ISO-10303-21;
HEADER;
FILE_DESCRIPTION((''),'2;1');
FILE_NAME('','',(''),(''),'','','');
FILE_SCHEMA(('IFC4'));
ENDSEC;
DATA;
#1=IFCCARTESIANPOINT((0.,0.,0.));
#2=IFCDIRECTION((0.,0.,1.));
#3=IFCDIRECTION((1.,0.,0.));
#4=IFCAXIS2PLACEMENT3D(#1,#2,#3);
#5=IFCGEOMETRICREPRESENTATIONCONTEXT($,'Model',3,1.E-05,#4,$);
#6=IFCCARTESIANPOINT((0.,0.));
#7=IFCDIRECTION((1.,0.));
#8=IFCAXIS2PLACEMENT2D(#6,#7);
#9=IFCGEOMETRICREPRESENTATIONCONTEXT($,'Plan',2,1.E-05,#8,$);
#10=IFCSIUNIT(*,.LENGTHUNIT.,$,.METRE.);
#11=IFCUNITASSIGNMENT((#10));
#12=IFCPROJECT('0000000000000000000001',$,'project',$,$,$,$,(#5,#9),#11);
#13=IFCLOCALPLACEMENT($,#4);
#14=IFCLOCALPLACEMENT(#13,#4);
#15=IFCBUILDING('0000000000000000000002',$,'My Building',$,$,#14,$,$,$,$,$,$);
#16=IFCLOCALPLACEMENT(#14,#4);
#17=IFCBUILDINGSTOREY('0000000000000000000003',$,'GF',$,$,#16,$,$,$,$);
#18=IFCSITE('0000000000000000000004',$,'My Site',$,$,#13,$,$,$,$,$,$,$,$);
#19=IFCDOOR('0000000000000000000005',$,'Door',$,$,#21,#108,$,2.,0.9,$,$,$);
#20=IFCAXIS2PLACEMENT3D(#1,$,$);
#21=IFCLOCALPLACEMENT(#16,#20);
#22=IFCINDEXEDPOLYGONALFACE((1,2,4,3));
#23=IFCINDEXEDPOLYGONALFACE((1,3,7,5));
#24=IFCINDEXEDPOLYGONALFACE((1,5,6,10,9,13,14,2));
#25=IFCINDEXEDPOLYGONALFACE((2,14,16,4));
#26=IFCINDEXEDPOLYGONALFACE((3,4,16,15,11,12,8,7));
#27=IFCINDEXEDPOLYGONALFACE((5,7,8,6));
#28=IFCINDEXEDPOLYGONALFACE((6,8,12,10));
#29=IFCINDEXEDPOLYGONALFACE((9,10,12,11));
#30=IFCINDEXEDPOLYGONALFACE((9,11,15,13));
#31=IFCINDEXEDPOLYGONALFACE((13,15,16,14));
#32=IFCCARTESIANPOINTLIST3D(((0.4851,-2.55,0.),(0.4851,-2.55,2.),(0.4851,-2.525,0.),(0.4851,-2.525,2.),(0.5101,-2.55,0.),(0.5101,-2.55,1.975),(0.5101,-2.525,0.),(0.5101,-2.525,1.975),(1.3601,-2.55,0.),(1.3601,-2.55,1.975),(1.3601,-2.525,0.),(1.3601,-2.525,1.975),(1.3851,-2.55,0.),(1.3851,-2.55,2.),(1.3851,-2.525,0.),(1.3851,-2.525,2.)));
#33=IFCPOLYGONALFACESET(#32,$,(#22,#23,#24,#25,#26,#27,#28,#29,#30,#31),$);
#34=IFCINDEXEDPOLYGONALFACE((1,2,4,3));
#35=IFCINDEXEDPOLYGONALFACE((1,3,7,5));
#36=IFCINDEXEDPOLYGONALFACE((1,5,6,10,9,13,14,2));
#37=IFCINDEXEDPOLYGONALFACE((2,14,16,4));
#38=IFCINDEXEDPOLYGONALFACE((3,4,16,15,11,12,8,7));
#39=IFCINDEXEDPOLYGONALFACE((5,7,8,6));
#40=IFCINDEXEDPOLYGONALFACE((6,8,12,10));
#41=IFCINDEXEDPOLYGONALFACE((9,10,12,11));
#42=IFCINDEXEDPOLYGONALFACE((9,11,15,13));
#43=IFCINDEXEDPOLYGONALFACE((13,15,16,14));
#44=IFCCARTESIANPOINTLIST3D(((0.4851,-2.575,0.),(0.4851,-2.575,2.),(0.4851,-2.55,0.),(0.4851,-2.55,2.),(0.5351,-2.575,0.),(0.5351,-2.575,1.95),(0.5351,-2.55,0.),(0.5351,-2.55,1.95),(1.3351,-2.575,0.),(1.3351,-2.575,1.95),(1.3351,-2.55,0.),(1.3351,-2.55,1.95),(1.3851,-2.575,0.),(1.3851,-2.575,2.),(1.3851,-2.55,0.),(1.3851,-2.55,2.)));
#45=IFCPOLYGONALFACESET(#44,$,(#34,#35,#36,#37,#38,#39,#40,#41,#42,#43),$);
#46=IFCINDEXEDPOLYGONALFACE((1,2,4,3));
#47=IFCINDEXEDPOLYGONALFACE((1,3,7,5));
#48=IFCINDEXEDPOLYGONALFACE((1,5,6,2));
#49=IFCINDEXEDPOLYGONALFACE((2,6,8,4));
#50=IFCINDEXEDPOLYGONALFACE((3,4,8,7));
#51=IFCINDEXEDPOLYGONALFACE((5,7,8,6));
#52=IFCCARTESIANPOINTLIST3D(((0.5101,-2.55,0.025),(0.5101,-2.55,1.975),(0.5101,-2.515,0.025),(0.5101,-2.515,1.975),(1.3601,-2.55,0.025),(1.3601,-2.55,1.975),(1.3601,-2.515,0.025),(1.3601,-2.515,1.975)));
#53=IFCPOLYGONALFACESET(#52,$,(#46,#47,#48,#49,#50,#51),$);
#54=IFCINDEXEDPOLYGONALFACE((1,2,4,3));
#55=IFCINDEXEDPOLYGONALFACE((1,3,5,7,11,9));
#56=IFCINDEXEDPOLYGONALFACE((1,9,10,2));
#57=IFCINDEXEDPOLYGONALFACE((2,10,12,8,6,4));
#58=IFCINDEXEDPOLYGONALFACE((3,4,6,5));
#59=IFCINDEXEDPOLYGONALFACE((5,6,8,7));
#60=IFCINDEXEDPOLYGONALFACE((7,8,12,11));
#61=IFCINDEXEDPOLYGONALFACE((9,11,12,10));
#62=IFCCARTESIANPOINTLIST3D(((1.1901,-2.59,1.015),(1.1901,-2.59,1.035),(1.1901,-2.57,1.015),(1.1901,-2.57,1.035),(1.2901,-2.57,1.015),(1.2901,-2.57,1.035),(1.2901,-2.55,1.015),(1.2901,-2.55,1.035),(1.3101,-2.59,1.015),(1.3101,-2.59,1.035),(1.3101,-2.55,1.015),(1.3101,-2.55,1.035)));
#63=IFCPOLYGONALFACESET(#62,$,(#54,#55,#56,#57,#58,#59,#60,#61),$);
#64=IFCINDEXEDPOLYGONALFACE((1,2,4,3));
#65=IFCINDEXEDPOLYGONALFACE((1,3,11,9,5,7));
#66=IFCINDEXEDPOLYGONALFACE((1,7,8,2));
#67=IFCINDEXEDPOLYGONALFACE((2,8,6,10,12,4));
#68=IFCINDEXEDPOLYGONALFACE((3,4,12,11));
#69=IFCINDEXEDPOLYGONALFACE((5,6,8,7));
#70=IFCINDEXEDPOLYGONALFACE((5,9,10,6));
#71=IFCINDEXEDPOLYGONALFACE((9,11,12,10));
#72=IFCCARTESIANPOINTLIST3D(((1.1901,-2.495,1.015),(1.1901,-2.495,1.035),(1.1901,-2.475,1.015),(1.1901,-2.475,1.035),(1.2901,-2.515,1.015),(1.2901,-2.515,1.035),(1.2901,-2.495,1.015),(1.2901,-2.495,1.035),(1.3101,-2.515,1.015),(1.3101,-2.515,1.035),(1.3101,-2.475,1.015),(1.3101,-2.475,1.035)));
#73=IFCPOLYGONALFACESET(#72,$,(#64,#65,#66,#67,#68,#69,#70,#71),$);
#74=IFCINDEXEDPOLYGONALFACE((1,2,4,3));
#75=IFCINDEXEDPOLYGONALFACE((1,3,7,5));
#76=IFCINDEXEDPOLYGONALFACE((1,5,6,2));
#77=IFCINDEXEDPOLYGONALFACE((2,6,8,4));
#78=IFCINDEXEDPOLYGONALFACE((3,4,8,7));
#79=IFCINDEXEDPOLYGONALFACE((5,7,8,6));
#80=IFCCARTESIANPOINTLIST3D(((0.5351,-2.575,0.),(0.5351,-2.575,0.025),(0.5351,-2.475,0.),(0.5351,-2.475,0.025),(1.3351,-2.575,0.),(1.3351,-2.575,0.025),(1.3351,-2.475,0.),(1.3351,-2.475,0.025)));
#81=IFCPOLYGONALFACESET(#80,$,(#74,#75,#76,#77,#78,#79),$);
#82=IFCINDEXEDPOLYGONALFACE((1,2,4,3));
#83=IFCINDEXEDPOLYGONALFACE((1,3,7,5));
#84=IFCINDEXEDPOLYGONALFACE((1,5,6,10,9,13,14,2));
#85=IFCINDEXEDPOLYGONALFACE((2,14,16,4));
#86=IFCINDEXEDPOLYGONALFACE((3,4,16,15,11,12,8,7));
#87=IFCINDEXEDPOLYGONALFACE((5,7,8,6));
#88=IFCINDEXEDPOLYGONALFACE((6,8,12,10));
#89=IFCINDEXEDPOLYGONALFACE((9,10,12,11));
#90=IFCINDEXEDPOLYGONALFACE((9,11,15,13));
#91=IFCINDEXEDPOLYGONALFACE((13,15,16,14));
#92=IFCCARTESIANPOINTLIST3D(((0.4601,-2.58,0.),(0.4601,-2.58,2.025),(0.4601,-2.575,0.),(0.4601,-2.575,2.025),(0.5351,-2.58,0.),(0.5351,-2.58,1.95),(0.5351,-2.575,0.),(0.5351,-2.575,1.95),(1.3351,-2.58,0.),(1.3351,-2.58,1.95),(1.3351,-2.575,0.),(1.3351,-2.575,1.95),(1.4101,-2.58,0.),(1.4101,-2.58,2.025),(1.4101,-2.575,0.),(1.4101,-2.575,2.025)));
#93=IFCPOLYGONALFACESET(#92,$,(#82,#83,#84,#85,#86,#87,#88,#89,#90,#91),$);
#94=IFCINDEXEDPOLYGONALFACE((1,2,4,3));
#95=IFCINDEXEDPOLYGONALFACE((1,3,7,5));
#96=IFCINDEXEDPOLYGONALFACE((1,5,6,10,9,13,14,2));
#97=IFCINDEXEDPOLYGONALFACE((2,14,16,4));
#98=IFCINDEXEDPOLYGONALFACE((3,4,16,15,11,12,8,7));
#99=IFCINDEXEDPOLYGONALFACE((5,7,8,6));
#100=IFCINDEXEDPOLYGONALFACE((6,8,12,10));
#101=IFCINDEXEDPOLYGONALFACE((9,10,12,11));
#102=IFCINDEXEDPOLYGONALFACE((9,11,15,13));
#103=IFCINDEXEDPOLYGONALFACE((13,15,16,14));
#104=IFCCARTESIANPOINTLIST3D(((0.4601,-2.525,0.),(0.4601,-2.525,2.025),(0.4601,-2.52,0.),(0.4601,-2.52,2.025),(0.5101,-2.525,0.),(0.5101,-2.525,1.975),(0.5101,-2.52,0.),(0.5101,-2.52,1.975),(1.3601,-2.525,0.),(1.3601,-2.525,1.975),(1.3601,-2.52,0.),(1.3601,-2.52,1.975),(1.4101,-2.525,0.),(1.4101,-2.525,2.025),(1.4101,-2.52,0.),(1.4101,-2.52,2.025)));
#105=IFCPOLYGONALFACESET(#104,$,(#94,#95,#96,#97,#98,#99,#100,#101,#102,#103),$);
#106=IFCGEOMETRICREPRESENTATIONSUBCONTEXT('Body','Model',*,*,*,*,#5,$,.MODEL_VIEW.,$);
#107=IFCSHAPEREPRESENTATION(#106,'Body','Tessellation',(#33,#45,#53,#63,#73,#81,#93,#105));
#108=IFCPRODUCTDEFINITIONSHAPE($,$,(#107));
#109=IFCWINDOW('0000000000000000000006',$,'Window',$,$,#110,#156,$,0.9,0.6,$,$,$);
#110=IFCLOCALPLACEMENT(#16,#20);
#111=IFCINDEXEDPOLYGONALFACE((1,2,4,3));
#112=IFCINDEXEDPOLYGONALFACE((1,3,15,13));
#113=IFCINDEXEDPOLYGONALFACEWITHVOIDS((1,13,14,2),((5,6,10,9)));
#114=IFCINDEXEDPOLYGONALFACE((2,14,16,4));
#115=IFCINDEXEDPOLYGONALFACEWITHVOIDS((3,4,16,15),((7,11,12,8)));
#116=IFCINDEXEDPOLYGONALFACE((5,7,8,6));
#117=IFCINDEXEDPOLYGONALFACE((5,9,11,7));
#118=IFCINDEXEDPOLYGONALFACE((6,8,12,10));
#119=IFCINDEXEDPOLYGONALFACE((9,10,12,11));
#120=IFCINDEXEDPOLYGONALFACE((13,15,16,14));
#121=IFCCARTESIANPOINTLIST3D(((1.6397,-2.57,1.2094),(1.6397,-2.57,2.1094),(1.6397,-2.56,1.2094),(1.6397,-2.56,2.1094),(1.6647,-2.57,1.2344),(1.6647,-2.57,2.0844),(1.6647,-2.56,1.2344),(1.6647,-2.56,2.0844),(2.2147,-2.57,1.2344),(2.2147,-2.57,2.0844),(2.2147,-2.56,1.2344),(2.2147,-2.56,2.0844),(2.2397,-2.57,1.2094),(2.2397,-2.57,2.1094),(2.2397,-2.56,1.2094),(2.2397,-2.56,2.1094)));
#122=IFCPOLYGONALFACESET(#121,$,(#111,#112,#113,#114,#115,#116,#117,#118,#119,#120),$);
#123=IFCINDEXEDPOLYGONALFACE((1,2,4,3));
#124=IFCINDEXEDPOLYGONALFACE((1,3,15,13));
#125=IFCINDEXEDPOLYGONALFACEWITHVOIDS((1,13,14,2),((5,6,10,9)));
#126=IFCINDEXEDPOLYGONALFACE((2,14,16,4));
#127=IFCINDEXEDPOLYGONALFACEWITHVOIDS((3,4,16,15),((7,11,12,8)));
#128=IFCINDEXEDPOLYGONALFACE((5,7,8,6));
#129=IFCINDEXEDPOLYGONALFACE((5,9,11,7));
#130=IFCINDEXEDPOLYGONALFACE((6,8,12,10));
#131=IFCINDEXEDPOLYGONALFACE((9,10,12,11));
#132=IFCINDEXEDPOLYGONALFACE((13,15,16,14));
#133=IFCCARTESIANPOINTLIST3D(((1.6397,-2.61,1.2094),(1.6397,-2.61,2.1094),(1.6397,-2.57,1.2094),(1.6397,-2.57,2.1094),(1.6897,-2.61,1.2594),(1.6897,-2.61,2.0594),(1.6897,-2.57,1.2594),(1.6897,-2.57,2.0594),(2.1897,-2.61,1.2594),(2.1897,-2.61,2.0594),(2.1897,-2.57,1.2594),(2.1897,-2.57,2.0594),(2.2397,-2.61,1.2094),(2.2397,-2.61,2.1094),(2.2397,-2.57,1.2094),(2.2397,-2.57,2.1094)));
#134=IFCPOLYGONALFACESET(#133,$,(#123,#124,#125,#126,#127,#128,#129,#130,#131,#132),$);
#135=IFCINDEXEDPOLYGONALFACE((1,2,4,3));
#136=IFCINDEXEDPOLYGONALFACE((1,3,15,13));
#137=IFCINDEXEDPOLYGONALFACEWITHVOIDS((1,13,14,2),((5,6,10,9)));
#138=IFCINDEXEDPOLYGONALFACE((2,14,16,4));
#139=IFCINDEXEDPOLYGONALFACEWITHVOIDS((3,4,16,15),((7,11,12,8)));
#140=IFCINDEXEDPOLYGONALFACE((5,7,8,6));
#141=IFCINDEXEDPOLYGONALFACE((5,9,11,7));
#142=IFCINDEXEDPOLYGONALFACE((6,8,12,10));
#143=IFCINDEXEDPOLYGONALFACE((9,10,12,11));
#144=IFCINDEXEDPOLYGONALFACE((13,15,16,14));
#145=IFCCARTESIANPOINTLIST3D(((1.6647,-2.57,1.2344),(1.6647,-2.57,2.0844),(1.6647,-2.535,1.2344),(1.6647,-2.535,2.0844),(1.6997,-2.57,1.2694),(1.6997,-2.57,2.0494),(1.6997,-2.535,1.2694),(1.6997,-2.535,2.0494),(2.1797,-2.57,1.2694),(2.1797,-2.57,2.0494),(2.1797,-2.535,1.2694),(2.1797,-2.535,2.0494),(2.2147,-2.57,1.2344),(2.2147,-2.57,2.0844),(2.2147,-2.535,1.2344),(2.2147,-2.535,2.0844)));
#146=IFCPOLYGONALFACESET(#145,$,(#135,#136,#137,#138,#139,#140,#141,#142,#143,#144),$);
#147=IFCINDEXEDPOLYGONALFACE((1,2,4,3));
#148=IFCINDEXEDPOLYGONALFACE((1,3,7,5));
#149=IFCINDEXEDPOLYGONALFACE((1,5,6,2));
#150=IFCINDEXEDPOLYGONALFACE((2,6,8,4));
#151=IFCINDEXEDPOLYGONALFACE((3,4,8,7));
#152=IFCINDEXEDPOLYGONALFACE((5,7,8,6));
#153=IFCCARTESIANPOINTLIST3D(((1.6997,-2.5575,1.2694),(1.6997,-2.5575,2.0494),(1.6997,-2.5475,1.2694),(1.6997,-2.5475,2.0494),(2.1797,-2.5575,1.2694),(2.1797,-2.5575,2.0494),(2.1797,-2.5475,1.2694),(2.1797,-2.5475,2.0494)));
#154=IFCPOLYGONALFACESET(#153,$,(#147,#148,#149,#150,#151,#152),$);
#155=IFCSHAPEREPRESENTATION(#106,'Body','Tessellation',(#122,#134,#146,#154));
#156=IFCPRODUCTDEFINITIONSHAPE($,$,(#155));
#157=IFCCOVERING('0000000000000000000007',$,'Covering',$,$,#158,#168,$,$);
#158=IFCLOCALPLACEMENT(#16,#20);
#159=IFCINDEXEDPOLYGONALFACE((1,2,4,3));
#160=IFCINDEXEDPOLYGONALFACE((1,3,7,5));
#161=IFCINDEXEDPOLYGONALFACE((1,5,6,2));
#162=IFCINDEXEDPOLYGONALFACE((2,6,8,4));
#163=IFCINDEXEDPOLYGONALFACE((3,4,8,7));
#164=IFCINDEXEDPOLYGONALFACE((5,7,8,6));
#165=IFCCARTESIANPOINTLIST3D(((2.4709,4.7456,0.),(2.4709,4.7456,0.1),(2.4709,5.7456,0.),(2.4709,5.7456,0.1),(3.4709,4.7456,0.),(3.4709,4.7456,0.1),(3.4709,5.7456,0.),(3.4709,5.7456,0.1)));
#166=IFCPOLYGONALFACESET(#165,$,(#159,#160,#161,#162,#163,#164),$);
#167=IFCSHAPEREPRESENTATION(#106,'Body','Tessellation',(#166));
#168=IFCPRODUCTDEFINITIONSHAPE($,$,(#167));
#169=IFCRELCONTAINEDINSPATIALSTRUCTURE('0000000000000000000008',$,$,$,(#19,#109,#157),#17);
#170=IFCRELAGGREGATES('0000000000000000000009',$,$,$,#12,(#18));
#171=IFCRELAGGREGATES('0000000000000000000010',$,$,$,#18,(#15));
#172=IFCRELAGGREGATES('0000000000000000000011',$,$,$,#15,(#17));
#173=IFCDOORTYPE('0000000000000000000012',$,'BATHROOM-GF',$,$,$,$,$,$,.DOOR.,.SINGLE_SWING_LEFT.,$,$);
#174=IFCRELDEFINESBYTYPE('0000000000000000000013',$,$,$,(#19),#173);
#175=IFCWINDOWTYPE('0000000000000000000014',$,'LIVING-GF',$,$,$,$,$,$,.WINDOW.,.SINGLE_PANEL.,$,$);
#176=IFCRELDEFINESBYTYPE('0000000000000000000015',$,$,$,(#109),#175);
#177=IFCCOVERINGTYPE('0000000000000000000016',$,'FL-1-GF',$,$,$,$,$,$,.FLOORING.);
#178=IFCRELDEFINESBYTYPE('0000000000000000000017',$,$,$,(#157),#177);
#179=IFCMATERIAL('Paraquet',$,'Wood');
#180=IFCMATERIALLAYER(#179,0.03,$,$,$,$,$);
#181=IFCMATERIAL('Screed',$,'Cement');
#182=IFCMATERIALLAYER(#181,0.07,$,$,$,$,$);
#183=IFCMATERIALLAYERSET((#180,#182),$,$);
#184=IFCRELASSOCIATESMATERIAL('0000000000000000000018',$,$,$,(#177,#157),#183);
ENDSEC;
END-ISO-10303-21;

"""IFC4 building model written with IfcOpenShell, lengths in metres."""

from ifc_helpers import new_model, entity, si_unit, frame, origin_with_axes, origin_2d_with_axis, place, context, subcontext, project, spatial, line, indexed_curve, outline, extrude, shape, source, transform, mapped, material, layer, layer_set, layer_usage, type_object, type_shapes, element, save


model = new_model("IFC4")

# Units and contexts
model_context = context("Model", 3, precision=1e-05, world=origin_with_axes())
plan_context = context("Plan", 2, precision=1e-05, world=origin_2d_with_axis())
body_context_1 = subcontext(model_context, "Body", "Model", "MODEL_VIEW")
body_context_2 = subcontext(plan_context, "Body", "Plan", "PLAN_VIEW")
ifc_project = project(units=[si_unit("LENGTHUNIT", "METRE")], contexts=[model_context, plan_context])

# Site, building, storey
site_placement = place(None, origin_with_axes())
site = spatial("IfcSite", under=ifc_project, at=site_placement, Name="My Site")
building_placement = place(site_placement, origin_with_axes())
building = spatial("IfcBuilding", under=site, at=building_placement, Name="My Building")
storey_placement = place(building_placement, origin_with_axes())
storey = spatial("IfcBuildingStorey", under=building, at=storey_placement, Name="GF")

# Shared definitions
door_type_1 = type_object("IfcDoorType", Name="BATHROOM-GF", OperationType="SINGLE_SWING_LEFT", PredefinedType="DOOR")
shared_shape_1 = source(origin_with_axes(), body_context_1, "Body", "SweptSolid", [
    extrude(outline(indexed_curve([(0.0, 0.0), (0.0, 2.0), (0.9, 2.0), (0.9, 0.0), (0.875, 0.0), (0.875, 1.975), (0.025, 1.975), (0.025, 0.0)], segments=[line(1, 2, 3, 4, 5, 6, 7, 8, 1)])), frame((0.0, 0.025, 0.0), z_axis=(0.0, -1.0, 0.0), x_axis=(1.0, 0.0, 0.0)), (0.0, 0.0, -1.0), 0.025),
    extrude(outline(indexed_curve([(0.0, 0.0), (0.0, 2.0), (0.9, 2.0), (0.9, 0.0), (0.85, 0.0), (0.85, 1.95), (0.05, 1.95), (0.05, 0.0)], segments=[line(1, 2, 3, 4, 5, 6, 7, 8, 1)])), frame((0.0, 0.0, 0.0), z_axis=(0.0, -1.0, 0.0), x_axis=(1.0, 0.0, 0.0)), (0.0, 0.0, -1.0), 0.025),
    extrude(outline(indexed_curve([(0.0, 0.0), (0.85, 0.0), (0.85, 0.035), (0.0, 0.035)], segments=[line(1, 2, 3, 4, 1)])), frame((0.025, 0.025, 0.025), z_axis=(0.0, 0.0, 1.0), x_axis=(1.0, 0.0, 0.0)), (0.0, 0.0, 1.0), 1.95),
    extrude(outline(indexed_curve([(0.0, 0.0), (0.0, -0.04), (-0.12, -0.04), (-0.12, -0.02), (-0.02, -0.02), (-0.02, 0.0)], segments=[line(1, 2, 3, 4, 5, 6, 1)])), frame((0.825, 0.025, 1.015), z_axis=(0.0, 0.0, 1.0), x_axis=(1.0, 0.0, 0.0)), (0.0, 0.0, 1.0), 0.02),
    extrude(outline(indexed_curve([(0.0, 0.0), (0.0, 0.04), (-0.12, 0.04), (-0.12, 0.02), (-0.02, 0.02), (-0.02, 0.0)], segments=[line(1, 2, 3, 4, 5, 6, 1)])), frame((0.825, 0.06, 1.015), z_axis=(0.0, 0.0, 1.0), x_axis=(1.0, 0.0, 0.0)), (0.0, 0.0, 1.0), 0.02),
    extrude(outline(indexed_curve([(0.0, 0.0), (0.8, 0.0), (0.8, 0.1), (0.0, 0.1)], segments=[line(1, 2, 3, 4, 1)])), frame((0.05, 0.0, 0.0), z_axis=(0.0, 0.0, 1.0), x_axis=(1.0, 0.0, 0.0)), (0.0, 0.0, 1.0), 0.025),
    extrude(outline(indexed_curve([(0.0, 0.0), (0.0, 2.025), (0.95, 2.025), (0.95, 0.0), (0.875, 0.0), (0.875, 1.95), (0.075, 1.95), (0.075, 0.0)], segments=[line(1, 2, 3, 4, 5, 6, 7, 8, 1)])), frame((-0.025, -0.005, 0.0), z_axis=(0.0, -1.0, 0.0), x_axis=(1.0, 0.0, 0.0)), (0.0, 0.0, -1.0), 0.005),
    extrude(outline(indexed_curve([(0.0, 0.0), (0.0, 2.025), (0.95, 2.025), (0.95, 0.0), (0.9, 0.0), (0.9, 1.975), (0.05, 1.975), (0.05, 0.0)], segments=[line(1, 2, 3, 4, 5, 6, 7, 8, 1)])), frame((-0.025, 0.05, 0.0), z_axis=(0.0, -1.0, 0.0), x_axis=(1.0, 0.0, 0.0)), (0.0, 0.0, -1.0), 0.005),
])
shared_shape_2 = source(origin_with_axes(), body_context_2, "Body", "Curve2D", [
    entity("IfcIndexedPolyCurve", entity("IfcCartesianPointList2D", [[0.0, 0.0], [0.0, 0.05], [0.025, 0.05], [0.025, 0.025], [0.05, 0.025], [0.05, 0.0]]), [entity("IfcLineIndex", [1, 2, 3, 4, 5, 6, 1])]),
    entity("IfcIndexedPolyCurve", entity("IfcCartesianPointList2D", [[0.9, 0.0], [0.9, 0.05], [0.875, 0.05], [0.875, 0.025], [0.85, 0.025], [0.85, 0.0]]), [entity("IfcLineIndex", [1, 2, 3, 4, 5, 6, 1])]),
    entity("IfcTrimmedCurve", entity("IfcEllipse", entity("IfcAxis2Placement2D", entity("IfcCartesianPoint", [0.06, 0.05]), entity("IfcDirection", [1.0, 0.0])), 0.815, 0.85), [entity("IfcCartesianPoint", [0.875, 0.05])], [entity("IfcCartesianPoint", [0.06, 0.9])], True, "CARTESIAN"),
    entity("IfcIndexedPolyCurve", entity("IfcCartesianPointList2D", [[0.025, 0.05], [0.06, 0.05], [0.06, 0.9], [0.025, 0.9]]), [entity("IfcLineIndex", [1, 2, 3, 4, 1])]),
])
type_shapes(door_type_1, [shared_shape_1, shared_shape_2])

# Door
door_1_placement = place(storey_placement, frame((0.4851, -2.575, 0.0), z_axis=(0.0, 0.0, 1.0), x_axis=(1.0, 0.0, 0.0)))
element("IfcDoor", 1, at=door_1_placement, inside=storey, type_object=door_type_1, Name="Door", OverallHeight=2.0, OverallWidth=0.9, shapes=[
    shape(body_context_1, "Body", "MappedRepresentation", [mapped(shared_shape_1, transform((0.0, 0.0, 0.0), x_axis=(1.0, 0.0, 0.0), y_axis=(0.0, 1.0, 0.0), z_axis=(0.0, 0.0, 1.0), scale=1.0))]),
    shape(body_context_2, "Body", "MappedRepresentation", [mapped(shared_shape_2, transform((0.0, 0.0, 0.0), x_axis=(1.0, 0.0, 0.0), y_axis=(0.0, 1.0, 0.0), z_axis=(0.0, 0.0, 1.0), scale=1.0))]),
])

# Window
window_type_1 = type_object("IfcWindowType", Name="LIVING-GF", PartitioningType="SINGLE_PANEL", PredefinedType="WINDOW")
shared_shape_3 = source(origin_with_axes(), body_context_1, "Body", "SweptSolid", [
    extrude(outline(indexed_curve([(0.0, 0.0), (0.6, 0.0), (0.6, 0.9), (0.0, 0.9)], segments=[line(1, 2, 3, 4, 1)]), holes=[indexed_curve([(0.025, 0.025), (0.575, 0.025), (0.575, 0.875), (0.025, 0.875)], segments=[line(1, 2, 3, 4, 1)])]), frame((0.0, 0.09, 0.0), z_axis=(0.0, -1.0, 0.0), x_axis=(1.0, 0.0, 0.0)), (0.0, 0.0, -1.0), 0.01),
    extrude(outline(indexed_curve([(0.0, 0.0), (0.6, 0.0), (0.6, 0.9), (0.0, 0.9)], segments=[line(1, 2, 3, 4, 1)]), holes=[indexed_curve([(0.05, 0.05), (0.55, 0.05), (0.55, 0.85), (0.05, 0.85)], segments=[line(1, 2, 3, 4, 1)])]), frame((0.0, 0.05, 0.0), z_axis=(0.0, -1.0, 0.0), x_axis=(1.0, 0.0, 0.0)), (0.0, 0.0, -1.0), 0.04),
    extrude(outline(indexed_curve([(0.0, 0.0), (0.55, 0.0), (0.55, 0.85), (0.0, 0.85)], segments=[line(1, 2, 3, 4, 1)]), holes=[indexed_curve([(0.035, 0.035), (0.515, 0.035), (0.515, 0.815), (0.035, 0.815)], segments=[line(1, 2, 3, 4, 1)])]), frame((0.025, 0.09, 0.025), z_axis=(0.0, -1.0, 0.0), x_axis=(1.0, 0.0, 0.0)), (0.0, 0.0, -1.0), 0.035),
    extrude(outline(indexed_curve([(0.035, 0.035), (0.515, 0.035), (0.515, 0.815), (0.035, 0.815)], segments=[line(1, 2, 3, 4, 1)])), frame((0.025, 0.1025, 0.025), z_axis=(0.0, -1.0, 0.0), x_axis=(1.0, 0.0, 0.0)), (0.0, 0.0, -1.0), 0.01),
])
shared_shape_4 = source(origin_with_axes(), body_context_2, "Body", "Curve2D", [
    entity("IfcIndexedPolyCurve", entity("IfcCartesianPointList2D", [[0.05, 0.05], [0.55, 0.05]])),
    entity("IfcIndexedPolyCurve", entity("IfcCartesianPointList2D", [[0.0, 0.1], [0.025, 0.1], [0.025, 0.09], [0.05, 0.09], [0.05, 0.05], [0.0, 0.05]]), [entity("IfcLineIndex", [1, 2, 3, 4, 5, 6, 1])]),
    entity("IfcIndexedPolyCurve", entity("IfcCartesianPointList2D", [[0.6, 0.1], [0.575, 0.1], [0.575, 0.09], [0.55, 0.09], [0.55, 0.05], [0.6, 0.05]]), [entity("IfcLineIndex", [1, 2, 3, 4, 5, 6, 1])]),
    entity("IfcIndexedPolyCurve", entity("IfcCartesianPointList2D", [[0.025, 0.09], [0.06, 0.09], [0.06, 0.125], [0.025, 0.125]]), [entity("IfcLineIndex", [1, 2, 3, 4, 1])]),
    entity("IfcIndexedPolyCurve", entity("IfcCartesianPointList2D", [[0.575, 0.09], [0.54, 0.09], [0.54, 0.125], [0.575, 0.125]]), [entity("IfcLineIndex", [1, 2, 3, 4, 1])]),
    entity("IfcIndexedPolyCurve", entity("IfcCartesianPointList2D", [[0.06, 0.09], [0.54, 0.09]])),
    entity("IfcIndexedPolyCurve", entity("IfcCartesianPointList2D", [[0.06, 0.125], [0.54, 0.125]])),
    entity("IfcIndexedPolyCurve", entity("IfcCartesianPointList2D", [[0.06, 0.1075], [0.54, 0.1075]])),
])
type_shapes(window_type_1, [shared_shape_3, shared_shape_4])
window_1_placement = place(storey_placement, frame((1.6397, -2.66, 1.2094), z_axis=(0.0, 0.0, 1.0), x_axis=(1.0, 0.0, 0.0)))
element("IfcWindow", 2, at=window_1_placement, inside=storey, type_object=window_type_1, Name="Window", OverallHeight=0.9, OverallWidth=0.6, shapes=[
    shape(body_context_1, "Body", "MappedRepresentation", [mapped(shared_shape_3, transform((0.0, 0.0, 0.0), x_axis=(1.0, 0.0, 0.0), y_axis=(0.0, 1.0, 0.0), z_axis=(0.0, 0.0, 1.0), scale=1.0))]),
    shape(body_context_2, "Body", "MappedRepresentation", [mapped(shared_shape_4, transform((0.0, 0.0, 0.0), x_axis=(1.0, 0.0, 0.0), y_axis=(0.0, 1.0, 0.0), z_axis=(0.0, 0.0, 1.0), scale=1.0))]),
])

# Covering
ifc_material_1 = material(Name="Paraquet", Category="Wood")
ifc_layer_1 = layer(ifc_material_1, 0.03)
ifc_material_2 = material(Name="Screed", Category="Cement")
ifc_layer_2 = layer(ifc_material_2, 0.07)
ifc_layer_set_1 = layer_set([ifc_layer_1, ifc_layer_2])
ifc_layer_usage_1 = layer_usage(ifc_layer_set_1, "AXIS3", "POSITIVE", 0.0)
covering_type = type_object("IfcCoveringType", Name="FL-1-GF", PredefinedType="FLOORING", material=ifc_layer_set_1)
covering_placement = place(storey_placement, frame((2.4709, 4.7456, 0.0), z_axis=(0.0, 0.0, 1.0), x_axis=(1.0, 0.0, 0.0)))
element("IfcCovering", 3, at=covering_placement, inside=storey, type_object=covering_type, material=ifc_layer_usage_1, Name="Covering", context=body_context_1, shape_type="SweptSolid", body=[
    extrude(outline(indexed_curve([(0.0, 0.0), (1.0, 0.0), (1.0, 1.0), (0.0, 1.0), (0.0, 0.0)])), origin_with_axes(), (0.0, 0.0, 1.0), 0.1),
])

save(model, "model.ifc")
